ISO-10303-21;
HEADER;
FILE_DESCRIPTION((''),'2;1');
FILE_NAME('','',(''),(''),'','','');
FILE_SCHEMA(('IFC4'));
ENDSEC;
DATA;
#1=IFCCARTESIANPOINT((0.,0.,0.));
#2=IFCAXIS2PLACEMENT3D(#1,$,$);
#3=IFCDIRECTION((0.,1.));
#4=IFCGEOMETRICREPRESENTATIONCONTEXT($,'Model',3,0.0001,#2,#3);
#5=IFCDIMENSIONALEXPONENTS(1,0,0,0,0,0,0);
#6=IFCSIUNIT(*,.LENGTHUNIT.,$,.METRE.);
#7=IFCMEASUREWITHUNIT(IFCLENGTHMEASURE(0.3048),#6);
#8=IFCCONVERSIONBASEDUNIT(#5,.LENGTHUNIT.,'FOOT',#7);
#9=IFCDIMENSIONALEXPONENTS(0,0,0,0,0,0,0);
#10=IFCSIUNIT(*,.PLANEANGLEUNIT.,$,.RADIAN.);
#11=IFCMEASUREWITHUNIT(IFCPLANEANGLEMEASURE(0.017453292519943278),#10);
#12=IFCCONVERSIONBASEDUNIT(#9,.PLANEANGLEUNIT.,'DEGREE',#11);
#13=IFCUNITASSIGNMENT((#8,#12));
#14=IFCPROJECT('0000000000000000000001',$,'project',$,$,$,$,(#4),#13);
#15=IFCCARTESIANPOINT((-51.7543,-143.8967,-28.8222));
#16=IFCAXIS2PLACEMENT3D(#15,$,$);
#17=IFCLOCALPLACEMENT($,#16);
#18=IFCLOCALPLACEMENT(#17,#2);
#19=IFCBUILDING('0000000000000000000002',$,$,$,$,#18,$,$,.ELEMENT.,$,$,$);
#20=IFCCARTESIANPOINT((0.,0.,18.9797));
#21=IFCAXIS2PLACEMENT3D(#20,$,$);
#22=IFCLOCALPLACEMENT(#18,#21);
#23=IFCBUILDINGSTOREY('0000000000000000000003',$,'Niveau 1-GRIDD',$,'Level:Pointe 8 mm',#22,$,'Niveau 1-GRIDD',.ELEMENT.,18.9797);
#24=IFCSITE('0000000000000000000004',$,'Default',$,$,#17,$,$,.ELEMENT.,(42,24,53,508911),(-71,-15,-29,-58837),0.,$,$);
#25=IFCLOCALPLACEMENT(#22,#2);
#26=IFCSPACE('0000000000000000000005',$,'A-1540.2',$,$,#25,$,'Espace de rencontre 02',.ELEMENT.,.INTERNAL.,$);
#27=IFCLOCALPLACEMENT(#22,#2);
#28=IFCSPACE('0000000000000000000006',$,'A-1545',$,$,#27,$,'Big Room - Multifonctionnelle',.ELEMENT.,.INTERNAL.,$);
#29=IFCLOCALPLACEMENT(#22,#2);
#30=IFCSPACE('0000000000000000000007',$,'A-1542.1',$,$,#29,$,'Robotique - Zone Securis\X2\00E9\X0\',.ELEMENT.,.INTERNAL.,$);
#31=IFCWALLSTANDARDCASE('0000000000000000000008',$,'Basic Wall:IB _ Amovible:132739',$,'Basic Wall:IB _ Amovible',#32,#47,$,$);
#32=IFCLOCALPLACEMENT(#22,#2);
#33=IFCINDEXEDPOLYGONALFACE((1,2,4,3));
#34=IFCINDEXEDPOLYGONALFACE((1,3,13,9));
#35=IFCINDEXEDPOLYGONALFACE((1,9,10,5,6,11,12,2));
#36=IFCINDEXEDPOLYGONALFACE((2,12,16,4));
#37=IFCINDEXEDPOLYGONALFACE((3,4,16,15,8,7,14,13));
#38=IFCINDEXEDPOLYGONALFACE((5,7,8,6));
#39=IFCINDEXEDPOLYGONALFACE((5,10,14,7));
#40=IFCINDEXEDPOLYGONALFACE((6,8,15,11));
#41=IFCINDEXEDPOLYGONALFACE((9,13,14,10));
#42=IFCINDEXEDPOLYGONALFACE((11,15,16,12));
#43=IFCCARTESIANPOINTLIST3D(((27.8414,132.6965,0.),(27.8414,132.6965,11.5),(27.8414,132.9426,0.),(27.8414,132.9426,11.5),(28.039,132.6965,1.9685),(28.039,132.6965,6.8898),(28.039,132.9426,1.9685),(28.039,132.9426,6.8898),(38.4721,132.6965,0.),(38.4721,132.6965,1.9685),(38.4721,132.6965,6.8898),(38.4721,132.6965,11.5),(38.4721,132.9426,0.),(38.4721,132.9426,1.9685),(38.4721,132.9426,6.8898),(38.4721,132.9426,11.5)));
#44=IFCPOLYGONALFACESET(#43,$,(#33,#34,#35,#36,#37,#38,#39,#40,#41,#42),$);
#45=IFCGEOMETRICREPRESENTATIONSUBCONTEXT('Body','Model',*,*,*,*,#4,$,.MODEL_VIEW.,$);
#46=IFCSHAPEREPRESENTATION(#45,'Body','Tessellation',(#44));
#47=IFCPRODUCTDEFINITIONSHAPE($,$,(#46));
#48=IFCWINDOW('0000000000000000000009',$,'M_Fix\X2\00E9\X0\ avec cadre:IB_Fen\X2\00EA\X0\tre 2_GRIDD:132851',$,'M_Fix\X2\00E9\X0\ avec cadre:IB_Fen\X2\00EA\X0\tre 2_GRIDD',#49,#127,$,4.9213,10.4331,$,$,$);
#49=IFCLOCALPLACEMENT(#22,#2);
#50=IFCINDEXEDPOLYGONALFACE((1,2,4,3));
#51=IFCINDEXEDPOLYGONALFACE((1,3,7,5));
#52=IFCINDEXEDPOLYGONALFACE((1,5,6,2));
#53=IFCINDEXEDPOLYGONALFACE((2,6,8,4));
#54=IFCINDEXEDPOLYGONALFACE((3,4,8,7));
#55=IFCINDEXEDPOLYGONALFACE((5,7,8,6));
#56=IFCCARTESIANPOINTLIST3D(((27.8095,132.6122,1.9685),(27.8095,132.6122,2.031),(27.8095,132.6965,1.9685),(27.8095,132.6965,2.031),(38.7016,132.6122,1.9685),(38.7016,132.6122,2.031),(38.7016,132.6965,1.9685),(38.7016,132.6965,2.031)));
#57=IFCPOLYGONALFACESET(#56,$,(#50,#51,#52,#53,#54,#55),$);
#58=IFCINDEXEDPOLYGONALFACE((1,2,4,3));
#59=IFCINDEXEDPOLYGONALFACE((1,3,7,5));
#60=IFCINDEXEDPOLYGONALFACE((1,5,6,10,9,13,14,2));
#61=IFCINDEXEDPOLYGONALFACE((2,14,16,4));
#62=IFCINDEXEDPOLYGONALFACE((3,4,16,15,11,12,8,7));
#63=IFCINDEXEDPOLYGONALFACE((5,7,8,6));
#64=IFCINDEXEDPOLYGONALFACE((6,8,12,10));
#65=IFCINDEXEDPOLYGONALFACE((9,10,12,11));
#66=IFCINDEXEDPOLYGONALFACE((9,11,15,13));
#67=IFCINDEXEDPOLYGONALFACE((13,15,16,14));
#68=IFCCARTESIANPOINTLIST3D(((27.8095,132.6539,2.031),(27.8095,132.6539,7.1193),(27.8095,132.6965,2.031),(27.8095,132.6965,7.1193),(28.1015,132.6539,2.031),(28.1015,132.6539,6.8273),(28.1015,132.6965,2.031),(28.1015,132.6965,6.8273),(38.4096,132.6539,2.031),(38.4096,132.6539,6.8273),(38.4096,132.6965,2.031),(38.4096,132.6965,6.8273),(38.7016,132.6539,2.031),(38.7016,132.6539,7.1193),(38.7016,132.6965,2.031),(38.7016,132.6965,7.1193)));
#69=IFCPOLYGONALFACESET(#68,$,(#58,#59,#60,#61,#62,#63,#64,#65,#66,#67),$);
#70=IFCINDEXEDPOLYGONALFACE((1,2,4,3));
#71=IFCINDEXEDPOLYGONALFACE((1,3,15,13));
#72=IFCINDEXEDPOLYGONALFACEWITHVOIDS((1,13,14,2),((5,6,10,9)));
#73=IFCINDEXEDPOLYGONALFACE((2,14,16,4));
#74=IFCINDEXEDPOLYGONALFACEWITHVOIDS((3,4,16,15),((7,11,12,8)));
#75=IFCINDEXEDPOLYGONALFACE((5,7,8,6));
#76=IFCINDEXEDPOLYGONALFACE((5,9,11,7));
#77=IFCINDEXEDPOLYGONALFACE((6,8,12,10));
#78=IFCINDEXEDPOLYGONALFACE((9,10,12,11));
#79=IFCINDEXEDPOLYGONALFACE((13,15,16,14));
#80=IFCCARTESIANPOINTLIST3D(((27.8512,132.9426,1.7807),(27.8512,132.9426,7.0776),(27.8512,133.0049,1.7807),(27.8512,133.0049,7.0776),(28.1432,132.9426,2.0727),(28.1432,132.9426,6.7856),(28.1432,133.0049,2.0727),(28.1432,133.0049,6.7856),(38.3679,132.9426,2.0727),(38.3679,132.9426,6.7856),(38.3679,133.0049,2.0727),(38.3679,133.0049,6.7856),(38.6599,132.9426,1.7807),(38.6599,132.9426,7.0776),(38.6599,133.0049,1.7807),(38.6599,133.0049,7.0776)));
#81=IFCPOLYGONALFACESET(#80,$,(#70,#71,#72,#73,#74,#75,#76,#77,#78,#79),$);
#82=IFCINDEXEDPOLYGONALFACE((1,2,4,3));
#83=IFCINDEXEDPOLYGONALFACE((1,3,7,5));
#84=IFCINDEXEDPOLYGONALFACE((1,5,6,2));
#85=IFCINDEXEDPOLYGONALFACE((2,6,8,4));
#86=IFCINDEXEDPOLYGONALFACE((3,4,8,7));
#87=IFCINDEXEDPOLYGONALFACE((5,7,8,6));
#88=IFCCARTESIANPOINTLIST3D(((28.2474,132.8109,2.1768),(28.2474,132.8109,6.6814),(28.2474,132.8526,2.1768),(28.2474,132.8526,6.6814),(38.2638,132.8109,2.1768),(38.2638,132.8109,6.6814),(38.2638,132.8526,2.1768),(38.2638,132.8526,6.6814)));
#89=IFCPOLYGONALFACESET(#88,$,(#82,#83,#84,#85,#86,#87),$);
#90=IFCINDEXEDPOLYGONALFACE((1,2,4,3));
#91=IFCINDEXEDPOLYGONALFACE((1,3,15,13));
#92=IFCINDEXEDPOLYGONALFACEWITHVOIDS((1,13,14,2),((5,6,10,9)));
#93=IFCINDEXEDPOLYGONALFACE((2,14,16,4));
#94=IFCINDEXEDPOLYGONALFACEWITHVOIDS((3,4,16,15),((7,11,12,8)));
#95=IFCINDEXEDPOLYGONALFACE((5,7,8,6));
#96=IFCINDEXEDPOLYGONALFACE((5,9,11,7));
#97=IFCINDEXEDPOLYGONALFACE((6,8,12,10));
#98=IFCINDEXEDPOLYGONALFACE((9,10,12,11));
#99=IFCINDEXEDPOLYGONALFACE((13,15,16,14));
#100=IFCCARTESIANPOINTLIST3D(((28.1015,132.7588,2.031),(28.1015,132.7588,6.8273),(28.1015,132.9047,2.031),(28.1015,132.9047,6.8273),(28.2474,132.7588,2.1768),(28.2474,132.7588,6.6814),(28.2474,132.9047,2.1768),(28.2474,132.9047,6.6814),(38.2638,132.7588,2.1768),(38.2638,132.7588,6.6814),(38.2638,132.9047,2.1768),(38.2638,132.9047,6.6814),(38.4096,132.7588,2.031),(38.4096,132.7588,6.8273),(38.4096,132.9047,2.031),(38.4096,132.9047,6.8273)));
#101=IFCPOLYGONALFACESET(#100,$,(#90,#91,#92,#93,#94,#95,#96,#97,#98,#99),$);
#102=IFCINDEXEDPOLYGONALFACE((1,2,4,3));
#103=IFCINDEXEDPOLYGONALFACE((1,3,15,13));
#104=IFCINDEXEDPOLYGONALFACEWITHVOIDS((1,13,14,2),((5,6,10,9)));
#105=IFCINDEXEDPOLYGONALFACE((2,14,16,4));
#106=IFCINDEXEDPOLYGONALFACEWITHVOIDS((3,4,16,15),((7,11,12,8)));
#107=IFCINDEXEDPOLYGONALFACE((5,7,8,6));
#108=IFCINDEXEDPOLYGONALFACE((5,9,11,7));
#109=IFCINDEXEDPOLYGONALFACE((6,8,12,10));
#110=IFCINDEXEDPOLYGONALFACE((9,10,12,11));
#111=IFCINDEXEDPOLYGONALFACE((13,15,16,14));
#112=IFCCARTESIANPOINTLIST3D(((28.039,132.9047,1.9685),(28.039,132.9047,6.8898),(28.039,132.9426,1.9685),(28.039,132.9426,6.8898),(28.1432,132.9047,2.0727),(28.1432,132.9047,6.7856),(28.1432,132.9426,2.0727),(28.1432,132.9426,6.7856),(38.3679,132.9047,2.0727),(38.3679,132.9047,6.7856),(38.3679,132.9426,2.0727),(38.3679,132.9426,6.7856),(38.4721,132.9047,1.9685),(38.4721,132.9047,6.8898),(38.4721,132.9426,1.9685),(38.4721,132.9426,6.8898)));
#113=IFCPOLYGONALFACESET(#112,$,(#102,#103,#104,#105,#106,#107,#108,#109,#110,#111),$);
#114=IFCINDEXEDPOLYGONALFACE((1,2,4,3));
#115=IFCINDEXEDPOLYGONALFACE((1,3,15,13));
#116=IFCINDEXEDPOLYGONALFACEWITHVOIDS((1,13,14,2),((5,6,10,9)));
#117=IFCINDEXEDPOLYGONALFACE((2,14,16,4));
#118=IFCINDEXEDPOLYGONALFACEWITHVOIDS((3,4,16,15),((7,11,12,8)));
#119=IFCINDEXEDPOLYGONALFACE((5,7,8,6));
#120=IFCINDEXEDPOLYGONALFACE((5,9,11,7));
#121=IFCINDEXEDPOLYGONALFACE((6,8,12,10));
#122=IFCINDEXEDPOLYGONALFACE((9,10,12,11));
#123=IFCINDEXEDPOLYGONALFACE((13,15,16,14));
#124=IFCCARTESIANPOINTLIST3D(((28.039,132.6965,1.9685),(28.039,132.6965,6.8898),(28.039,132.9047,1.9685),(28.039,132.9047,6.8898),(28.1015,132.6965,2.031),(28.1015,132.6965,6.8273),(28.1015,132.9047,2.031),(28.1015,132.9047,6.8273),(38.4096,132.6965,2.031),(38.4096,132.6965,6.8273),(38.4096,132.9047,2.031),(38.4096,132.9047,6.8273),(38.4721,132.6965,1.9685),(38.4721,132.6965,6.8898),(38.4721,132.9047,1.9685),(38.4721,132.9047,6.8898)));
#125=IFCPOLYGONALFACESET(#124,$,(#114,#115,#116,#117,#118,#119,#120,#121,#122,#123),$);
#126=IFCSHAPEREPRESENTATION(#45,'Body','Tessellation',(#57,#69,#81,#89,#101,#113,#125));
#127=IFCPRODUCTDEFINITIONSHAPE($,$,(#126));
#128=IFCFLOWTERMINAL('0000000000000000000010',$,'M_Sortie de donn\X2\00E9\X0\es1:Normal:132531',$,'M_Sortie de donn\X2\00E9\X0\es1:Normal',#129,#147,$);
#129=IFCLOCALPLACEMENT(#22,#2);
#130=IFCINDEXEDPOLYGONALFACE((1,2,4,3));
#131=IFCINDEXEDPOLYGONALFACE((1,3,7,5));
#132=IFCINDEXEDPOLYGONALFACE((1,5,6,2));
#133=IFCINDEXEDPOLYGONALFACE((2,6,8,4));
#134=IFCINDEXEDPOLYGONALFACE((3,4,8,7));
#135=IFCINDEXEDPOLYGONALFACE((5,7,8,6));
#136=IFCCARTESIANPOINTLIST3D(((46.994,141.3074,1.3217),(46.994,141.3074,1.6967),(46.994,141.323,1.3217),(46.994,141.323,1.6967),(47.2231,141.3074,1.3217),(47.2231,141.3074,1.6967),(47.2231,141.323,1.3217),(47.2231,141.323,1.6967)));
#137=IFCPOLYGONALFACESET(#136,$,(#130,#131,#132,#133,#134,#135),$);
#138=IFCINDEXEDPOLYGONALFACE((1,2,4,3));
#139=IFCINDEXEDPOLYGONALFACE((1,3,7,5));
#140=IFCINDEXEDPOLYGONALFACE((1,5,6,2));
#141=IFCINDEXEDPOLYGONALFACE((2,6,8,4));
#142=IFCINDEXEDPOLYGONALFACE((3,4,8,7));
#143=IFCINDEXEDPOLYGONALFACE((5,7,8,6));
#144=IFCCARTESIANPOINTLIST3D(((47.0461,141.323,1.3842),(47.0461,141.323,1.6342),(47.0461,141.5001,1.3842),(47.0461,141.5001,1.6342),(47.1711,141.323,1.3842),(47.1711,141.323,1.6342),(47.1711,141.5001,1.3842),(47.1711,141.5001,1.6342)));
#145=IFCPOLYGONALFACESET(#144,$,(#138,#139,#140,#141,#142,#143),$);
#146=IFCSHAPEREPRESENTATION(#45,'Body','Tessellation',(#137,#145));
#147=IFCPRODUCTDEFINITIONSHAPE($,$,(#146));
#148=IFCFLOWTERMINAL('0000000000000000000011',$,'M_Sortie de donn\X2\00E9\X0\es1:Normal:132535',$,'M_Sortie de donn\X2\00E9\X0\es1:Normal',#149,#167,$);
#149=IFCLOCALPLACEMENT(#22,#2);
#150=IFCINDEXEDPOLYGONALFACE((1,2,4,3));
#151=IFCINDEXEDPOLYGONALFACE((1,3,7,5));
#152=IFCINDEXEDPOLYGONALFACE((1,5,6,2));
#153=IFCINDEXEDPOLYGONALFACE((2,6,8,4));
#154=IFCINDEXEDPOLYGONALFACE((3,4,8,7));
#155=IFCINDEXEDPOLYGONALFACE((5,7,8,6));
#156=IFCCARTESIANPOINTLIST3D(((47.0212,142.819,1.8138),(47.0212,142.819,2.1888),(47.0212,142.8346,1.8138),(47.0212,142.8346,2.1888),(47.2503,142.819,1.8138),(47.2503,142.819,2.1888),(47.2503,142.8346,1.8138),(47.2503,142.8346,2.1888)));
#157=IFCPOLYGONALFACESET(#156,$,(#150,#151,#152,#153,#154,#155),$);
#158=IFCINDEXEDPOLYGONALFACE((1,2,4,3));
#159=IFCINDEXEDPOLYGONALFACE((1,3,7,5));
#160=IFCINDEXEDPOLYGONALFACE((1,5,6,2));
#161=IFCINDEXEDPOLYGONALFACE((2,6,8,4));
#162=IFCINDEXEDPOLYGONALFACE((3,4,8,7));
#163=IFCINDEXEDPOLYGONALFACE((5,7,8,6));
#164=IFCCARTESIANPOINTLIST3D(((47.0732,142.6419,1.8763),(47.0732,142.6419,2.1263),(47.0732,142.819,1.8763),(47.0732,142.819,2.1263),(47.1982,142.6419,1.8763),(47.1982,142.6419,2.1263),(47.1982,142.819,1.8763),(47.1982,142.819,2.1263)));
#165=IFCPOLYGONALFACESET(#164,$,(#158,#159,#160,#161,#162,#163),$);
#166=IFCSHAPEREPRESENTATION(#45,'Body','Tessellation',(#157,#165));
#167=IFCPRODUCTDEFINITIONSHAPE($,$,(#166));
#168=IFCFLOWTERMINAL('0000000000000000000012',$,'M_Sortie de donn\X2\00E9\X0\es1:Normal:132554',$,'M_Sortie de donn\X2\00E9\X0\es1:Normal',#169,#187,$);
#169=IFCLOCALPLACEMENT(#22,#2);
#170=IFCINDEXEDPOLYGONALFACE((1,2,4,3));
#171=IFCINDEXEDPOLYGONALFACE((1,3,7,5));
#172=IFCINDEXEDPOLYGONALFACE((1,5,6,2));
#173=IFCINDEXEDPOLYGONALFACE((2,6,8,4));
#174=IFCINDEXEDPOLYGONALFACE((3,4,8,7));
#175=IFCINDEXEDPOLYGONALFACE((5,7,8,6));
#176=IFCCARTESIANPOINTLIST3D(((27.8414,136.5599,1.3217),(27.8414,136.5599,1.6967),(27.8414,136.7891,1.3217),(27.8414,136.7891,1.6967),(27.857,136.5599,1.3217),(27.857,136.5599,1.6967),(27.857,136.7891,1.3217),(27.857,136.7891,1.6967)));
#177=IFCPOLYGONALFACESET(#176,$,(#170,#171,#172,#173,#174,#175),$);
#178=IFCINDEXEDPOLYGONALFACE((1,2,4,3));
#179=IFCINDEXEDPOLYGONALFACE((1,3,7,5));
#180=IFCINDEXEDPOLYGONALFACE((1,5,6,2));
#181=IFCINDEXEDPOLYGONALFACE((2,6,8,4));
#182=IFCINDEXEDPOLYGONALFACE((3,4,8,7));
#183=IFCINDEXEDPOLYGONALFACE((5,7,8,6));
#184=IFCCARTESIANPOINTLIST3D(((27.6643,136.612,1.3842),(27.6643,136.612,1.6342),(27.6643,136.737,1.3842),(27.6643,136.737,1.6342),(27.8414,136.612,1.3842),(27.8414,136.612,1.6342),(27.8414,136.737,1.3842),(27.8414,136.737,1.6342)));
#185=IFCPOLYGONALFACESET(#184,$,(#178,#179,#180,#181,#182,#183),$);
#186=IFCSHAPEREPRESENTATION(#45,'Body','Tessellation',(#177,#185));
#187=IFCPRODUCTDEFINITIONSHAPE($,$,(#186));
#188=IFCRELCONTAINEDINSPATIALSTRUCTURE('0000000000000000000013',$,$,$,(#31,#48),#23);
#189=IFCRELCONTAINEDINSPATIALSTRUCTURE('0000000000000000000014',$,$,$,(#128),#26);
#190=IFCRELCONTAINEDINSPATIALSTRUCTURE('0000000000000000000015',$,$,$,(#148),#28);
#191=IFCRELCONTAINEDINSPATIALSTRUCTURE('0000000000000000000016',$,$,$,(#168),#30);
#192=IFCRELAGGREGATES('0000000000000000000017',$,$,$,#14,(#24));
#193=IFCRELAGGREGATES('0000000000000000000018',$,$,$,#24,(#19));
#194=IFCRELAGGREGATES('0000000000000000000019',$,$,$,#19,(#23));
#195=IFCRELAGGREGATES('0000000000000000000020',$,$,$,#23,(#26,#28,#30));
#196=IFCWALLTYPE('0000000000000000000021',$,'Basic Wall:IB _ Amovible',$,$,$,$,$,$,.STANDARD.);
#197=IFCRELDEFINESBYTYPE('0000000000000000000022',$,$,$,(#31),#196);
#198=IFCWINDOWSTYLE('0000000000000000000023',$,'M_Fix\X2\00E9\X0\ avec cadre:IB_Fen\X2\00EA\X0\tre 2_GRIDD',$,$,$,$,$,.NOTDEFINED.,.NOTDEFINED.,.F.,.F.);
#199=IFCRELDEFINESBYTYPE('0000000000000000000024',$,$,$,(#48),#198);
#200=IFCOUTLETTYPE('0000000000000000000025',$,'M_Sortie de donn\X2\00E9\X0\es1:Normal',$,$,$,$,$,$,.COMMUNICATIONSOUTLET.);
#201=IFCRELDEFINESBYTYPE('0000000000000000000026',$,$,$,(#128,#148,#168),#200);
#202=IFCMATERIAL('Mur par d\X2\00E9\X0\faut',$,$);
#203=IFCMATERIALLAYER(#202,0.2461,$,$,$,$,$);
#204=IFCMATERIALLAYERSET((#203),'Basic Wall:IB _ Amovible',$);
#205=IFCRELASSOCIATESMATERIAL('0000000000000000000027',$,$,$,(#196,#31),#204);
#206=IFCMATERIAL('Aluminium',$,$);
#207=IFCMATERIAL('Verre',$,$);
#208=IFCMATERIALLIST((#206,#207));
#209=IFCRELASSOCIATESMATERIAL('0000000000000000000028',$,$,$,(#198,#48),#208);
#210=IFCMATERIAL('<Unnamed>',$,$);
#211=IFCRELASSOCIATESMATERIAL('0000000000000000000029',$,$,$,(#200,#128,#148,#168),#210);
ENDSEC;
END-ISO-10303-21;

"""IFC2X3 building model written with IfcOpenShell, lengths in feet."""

from ifc_helpers import new_model, entity, si_unit, converted_unit, direction, frame, frame_2d, origin, origin_2d_with_axis, place, context, subcontext, project, spatial, polyline, rectangle, outline, extrude, source, transform, mapped, material, material_list, layer, layer_set, layer_usage, type_object, type_shapes, element, fill, save


model = new_model("IFC2X3")

# Units and contexts
model_context = context("Model", 3, precision=0.0001, world=origin(), true_north=direction((0.0, 1.0)))
body_context = subcontext(model_context, "Body", "Model", "MODEL_VIEW")
ifc_project = project(units=[converted_unit("LENGTHUNIT", "FOOT", entity("IfcLengthMeasure", 0.3048), si_unit("LENGTHUNIT", "METRE"), dimensions=[1, 0, 0, 0, 0, 0, 0]), converted_unit("PLANEANGLEUNIT", "DEGREE", entity("IfcPlaneAngleMeasure", 0.017453292519943278), si_unit("PLANEANGLEUNIT", "RADIAN"), dimensions=[0, 0, 0, 0, 0, 0, 0])], contexts=[model_context])

# Site, building, storey
site_placement = place(None, frame((-51.7543, -143.8967, -28.8222)))
site = spatial("IfcSite", under=ifc_project, at=site_placement, Name="Default", CompositionType="ELEMENT", RefLatitude=(42, 24, 53, 508911), RefLongitude=(-71, -15, -29, -58837), RefElevation=0.0)
building_placement = place(site_placement, origin())
building = spatial("IfcBuilding", under=site, at=building_placement, CompositionType="ELEMENT")
storey_placement = place(building_placement, frame((0.0, 0.0, 18.9797)))
storey = spatial("IfcBuildingStorey", under=building, at=storey_placement, Name="Niveau 1-GRIDD", ObjectType="Level:Pointe 8 mm", LongName="Niveau 1-GRIDD", CompositionType="ELEMENT", Elevation=18.9797)

# Wall, opening, window
ifc_material_1 = material(Name="Mur par défaut")
ifc_layer_1 = layer(ifc_material_1, 0.2461)
ifc_layer_set_1 = layer_set([ifc_layer_1], Name="Basic Wall:IB _ Amovible")
ifc_layer_usage_1 = layer_usage(ifc_layer_set_1, "AXIS2", "NEGATIVE", 0.123)
wall_type_1 = type_object("IfcWallType", Name="Basic Wall:IB _ Amovible", PredefinedType="STANDARD", material=ifc_layer_set_1)
wall_1_placement = place(storey_placement, frame((27.8414, 132.8195, 0.0)))
wall_1 = element("IfcWallStandardCase", 1, at=wall_1_placement, inside=storey, type_object=wall_type_1, material=ifc_layer_usage_1, Name="Basic Wall:IB _ Amovible:132739", ObjectType="Basic Wall:IB _ Amovible", context=body_context, shape_type="SweptSolid", body=[
    extrude(rectangle(XDim=10.6307, YDim=0.2461, at=frame_2d((5.3154, 0.0), x_axis=(-1.0, 0.0))), origin(), (0.0, 0.0, 1.0), 11.5),
])
opening_placement = place(wall_1_placement, frame((10.6307, 0.123, 1.9685)))
opening = element("IfcOpeningElement", 2, at=opening_placement, cuts=wall_1, ObjectType="Opening", context=body_context, shape_type="SweptSolid", body=[
    extrude(rectangle(XDim=4.9213, YDim=10.4331, at=frame_2d((2.4606, 5.2165), x_axis=(-1.0, 0.0))), frame((0.0, 0.0, 0.0), z_axis=(0.0, -1.0, 0.0), x_axis=(0.0, 0.0, 1.0)), (0.0, 0.0, 1.0), 0.2461),
])
ifc_material_2 = material(Name="Aluminium")
ifc_material_3 = material(Name="Verre")
ifc_material_list_1 = material_list([ifc_material_2, ifc_material_3])
window_style = type_object("IfcWindowStyle", Name="M_Fixé avec cadre:IB_Fenêtre 2_GRIDD", ConstructionType="NOTDEFINED", OperationType="NOTDEFINED", ParameterTakesPrecedence=False, Sizeable=False, material=ifc_material_list_1)
shared_shape_1 = source(origin(), body_context, "Body", "SweptSolid", [
    extrude(rectangle(XDim=10.8921, YDim=0.0843, at=origin_2d_with_axis()), frame((5.4665, 0.2882, 0.0), z_axis=(0.0, 0.0, 1.0), x_axis=(-1.0, 0.0, 0.0)), (0.0, 0.0, 1.0), 0.0625),
    extrude(outline(polyline([(-2.3251, 5.154), (2.4711, 5.154), (2.4711, 5.446), (-2.6171, 5.446), (-2.6171, -5.446), (2.4711, -5.446), (2.4711, -5.154), (-2.3251, -5.154), (-2.3251, 5.154)])), frame((5.4665, 0.2887, 2.5336), z_axis=(0.0, -1.0, 0.0), x_axis=(0.0, 0.0, -1.0)), (0.0, 0.0, 1.0), 0.0427),
    extrude(outline(polyline([(-2.6485, -5.4044), (2.6485, -5.4044), (2.6485, 5.4044), (-2.6485, 5.4044), (-2.6485, -5.4044)]), holes=[polyline([(-2.3565, -5.1124), (-2.3565, 5.1124), (2.3565, 5.1124), (2.3565, -5.1124), (-2.3565, -5.1124)])]), frame((5.4665, 0.0, 2.4606), z_axis=(0.0, -1.0, 0.0), x_axis=(0.0, 0.0, -1.0)), (0.0, 0.0, 1.0), 0.0623),
    extrude(rectangle(XDim=10.0164, YDim=0.0417, at=origin_2d_with_axis()), frame((5.4665, 0.1108, 0.2083)), (0.0, 0.0, 1.0), 4.5046),
    extrude(outline(polyline([(-5.154, -2.3981), (5.154, -2.3981), (5.154, 2.3981), (-5.154, 2.3981), (-5.154, -2.3981)]), holes=[polyline([(-5.0082, -2.2523), (-5.0082, 2.2523), (5.0082, 2.2523), (5.0082, -2.2523), (-5.0082, -2.2523)])]), frame((5.4665, 0.1837, 2.4606), z_axis=(0.0, -1.0, 0.0), x_axis=(-1.0, 0.0, 0.0)), (0.0, 0.0, 1.0), 0.1458),
    extrude(outline(polyline([(-5.2165, -2.4606), (5.2165, -2.4606), (5.2165, 2.4606), (-5.2165, 2.4606), (-5.2165, -2.4606)]), holes=[polyline([(-5.1124, -2.3565), (-5.1124, 2.3565), (5.1124, 2.3565), (5.1124, -2.3565), (-5.1124, -2.3565)])]), frame((5.4665, 0.0379, 2.4606), z_axis=(0.0, -1.0, 0.0), x_axis=(-1.0, 0.0, 0.0)), (0.0, 0.0, 1.0), 0.0379),
    extrude(outline(polyline([(-2.4606, -5.2165), (2.4606, -5.2165), (2.4606, 5.2165), (-2.4606, 5.2165), (-2.4606, -5.2165)]), holes=[polyline([(-2.3981, -5.154), (-2.3981, 5.154), (2.3981, 5.154), (2.3981, -5.154), (-2.3981, -5.154)])]), frame((5.4665, 0.2461, 2.4606), z_axis=(0.0, -1.0, 0.0), x_axis=(0.0, 0.0, -1.0)), (0.0, 0.0, 1.0), 0.2082),
])
type_shapes(window_style, [shared_shape_1])
window_placement = place(opening_placement, frame((0.25, 0.0, 0.0), z_axis=(0.0, 0.0, 1.0), x_axis=(-1.0, 0.0, 0.0)))
window = element("IfcWindow", 3, at=window_placement, inside=storey, type_object=window_style, material=ifc_material_list_1, Name="M_Fixé avec cadre:IB_Fenêtre 2_GRIDD:132851", ObjectType="M_Fixé avec cadre:IB_Fenêtre 2_GRIDD", OverallHeight=4.9213, OverallWidth=10.4331, context=body_context, shape_type="MappedRepresentation", body=[
    mapped(shared_shape_1, transform((0.0, 0.0, 0.0), scale=1.0)),
])
fill(opening, window)

# Shared definitions
space_1_placement = place(storey_placement, origin())
space_1 = spatial("IfcSpace", under=storey, at=space_1_placement, Name="A-1540.2", LongName="Espace de rencontre 02", CompositionType="ELEMENT", InteriorOrExteriorSpace="INTERNAL")

# Flow terminal
ifc_material_4 = material(Name="<Unnamed>")
outlet_type = type_object("IfcOutletType", Name="M_Sortie de données1:Normal", PredefinedType="COMMUNICATIONSOUTLET", material=ifc_material_4)
shared_shape_2 = source(origin(), body_context, "Body", "SweptSolid", [
    extrude(rectangle(XDim=0.2292, YDim=0.375, at=frame_2d((0.0, 0.0), x_axis=(1.0, 0.0))), frame((0.0, 0.0, 0.0), z_axis=(0.0, 0.0, 1.0), x_axis=(-1.0, 0.0, 0.0)), (0.0, 0.0, 1.0), 0.0156),
    extrude(rectangle(XDim=0.125, YDim=0.25, at=frame_2d((0.0, 0.0), x_axis=(1.0, 0.0))), frame((0.0, 0.0, -0.1771), z_axis=(0.0, 0.0, 1.0), x_axis=(-1.0, 0.0, 0.0)), (0.0, 0.0, 1.0), 0.1771),
])
type_shapes(outlet_type, [shared_shape_2])
flow_terminal_1_placement = place(space_1_placement, frame((47.1086, 141.323, 1.5092), z_axis=(0.0, -1.0, 0.0), x_axis=(1.0, 0.0, 0.0)))
element("IfcFlowTerminal", 4, at=flow_terminal_1_placement, inside=space_1, type_object=outlet_type, material=ifc_material_4, Name="M_Sortie de données1:Normal:132531", ObjectType="M_Sortie de données1:Normal", context=body_context, shape_type="MappedRepresentation", body=[
    mapped(shared_shape_2, transform((0.0, 0.0, 0.0), scale=1.0)),
])

# Shared definitions
space_2_placement = place(storey_placement, origin())
space_2 = spatial("IfcSpace", under=storey, at=space_2_placement, Name="A-1545", LongName="Big Room - Multifonctionnelle", CompositionType="ELEMENT", InteriorOrExteriorSpace="INTERNAL")

# Flow terminal
flow_terminal_2_placement = place(space_2_placement, frame((47.1357, 142.819, 2.0013), z_axis=(0.0, 1.0, 0.0), x_axis=(-1.0, 0.0, 0.0)))
element("IfcFlowTerminal", 5, at=flow_terminal_2_placement, inside=space_2, type_object=outlet_type, material=ifc_material_4, Name="M_Sortie de données1:Normal:132535", ObjectType="M_Sortie de données1:Normal", context=body_context, shape_type="MappedRepresentation", body=[
    mapped(shared_shape_2, transform((0.0, 0.0, 0.0), scale=1.0)),
])

# Shared definitions
space_3_placement = place(storey_placement, origin())
space_3 = spatial("IfcSpace", under=storey, at=space_3_placement, Name="A-1542.1", LongName="Robotique - Zone Securisé", CompositionType="ELEMENT", InteriorOrExteriorSpace="INTERNAL")

# Flow terminal
flow_terminal_3_placement = place(space_3_placement, frame((27.8414, 136.6745, 1.5092), z_axis=(1.0, 0.0, 0.0), x_axis=(0.0, 1.0, 0.0)))
element("IfcFlowTerminal", 6, at=flow_terminal_3_placement, inside=space_3, type_object=outlet_type, material=ifc_material_4, Name="M_Sortie de données1:Normal:132554", ObjectType="M_Sortie de données1:Normal", context=body_context, shape_type="MappedRepresentation", body=[
    mapped(shared_shape_2, transform((0.0, 0.0, 0.0), scale=1.0)),
])

save(model, "model.ifc")
